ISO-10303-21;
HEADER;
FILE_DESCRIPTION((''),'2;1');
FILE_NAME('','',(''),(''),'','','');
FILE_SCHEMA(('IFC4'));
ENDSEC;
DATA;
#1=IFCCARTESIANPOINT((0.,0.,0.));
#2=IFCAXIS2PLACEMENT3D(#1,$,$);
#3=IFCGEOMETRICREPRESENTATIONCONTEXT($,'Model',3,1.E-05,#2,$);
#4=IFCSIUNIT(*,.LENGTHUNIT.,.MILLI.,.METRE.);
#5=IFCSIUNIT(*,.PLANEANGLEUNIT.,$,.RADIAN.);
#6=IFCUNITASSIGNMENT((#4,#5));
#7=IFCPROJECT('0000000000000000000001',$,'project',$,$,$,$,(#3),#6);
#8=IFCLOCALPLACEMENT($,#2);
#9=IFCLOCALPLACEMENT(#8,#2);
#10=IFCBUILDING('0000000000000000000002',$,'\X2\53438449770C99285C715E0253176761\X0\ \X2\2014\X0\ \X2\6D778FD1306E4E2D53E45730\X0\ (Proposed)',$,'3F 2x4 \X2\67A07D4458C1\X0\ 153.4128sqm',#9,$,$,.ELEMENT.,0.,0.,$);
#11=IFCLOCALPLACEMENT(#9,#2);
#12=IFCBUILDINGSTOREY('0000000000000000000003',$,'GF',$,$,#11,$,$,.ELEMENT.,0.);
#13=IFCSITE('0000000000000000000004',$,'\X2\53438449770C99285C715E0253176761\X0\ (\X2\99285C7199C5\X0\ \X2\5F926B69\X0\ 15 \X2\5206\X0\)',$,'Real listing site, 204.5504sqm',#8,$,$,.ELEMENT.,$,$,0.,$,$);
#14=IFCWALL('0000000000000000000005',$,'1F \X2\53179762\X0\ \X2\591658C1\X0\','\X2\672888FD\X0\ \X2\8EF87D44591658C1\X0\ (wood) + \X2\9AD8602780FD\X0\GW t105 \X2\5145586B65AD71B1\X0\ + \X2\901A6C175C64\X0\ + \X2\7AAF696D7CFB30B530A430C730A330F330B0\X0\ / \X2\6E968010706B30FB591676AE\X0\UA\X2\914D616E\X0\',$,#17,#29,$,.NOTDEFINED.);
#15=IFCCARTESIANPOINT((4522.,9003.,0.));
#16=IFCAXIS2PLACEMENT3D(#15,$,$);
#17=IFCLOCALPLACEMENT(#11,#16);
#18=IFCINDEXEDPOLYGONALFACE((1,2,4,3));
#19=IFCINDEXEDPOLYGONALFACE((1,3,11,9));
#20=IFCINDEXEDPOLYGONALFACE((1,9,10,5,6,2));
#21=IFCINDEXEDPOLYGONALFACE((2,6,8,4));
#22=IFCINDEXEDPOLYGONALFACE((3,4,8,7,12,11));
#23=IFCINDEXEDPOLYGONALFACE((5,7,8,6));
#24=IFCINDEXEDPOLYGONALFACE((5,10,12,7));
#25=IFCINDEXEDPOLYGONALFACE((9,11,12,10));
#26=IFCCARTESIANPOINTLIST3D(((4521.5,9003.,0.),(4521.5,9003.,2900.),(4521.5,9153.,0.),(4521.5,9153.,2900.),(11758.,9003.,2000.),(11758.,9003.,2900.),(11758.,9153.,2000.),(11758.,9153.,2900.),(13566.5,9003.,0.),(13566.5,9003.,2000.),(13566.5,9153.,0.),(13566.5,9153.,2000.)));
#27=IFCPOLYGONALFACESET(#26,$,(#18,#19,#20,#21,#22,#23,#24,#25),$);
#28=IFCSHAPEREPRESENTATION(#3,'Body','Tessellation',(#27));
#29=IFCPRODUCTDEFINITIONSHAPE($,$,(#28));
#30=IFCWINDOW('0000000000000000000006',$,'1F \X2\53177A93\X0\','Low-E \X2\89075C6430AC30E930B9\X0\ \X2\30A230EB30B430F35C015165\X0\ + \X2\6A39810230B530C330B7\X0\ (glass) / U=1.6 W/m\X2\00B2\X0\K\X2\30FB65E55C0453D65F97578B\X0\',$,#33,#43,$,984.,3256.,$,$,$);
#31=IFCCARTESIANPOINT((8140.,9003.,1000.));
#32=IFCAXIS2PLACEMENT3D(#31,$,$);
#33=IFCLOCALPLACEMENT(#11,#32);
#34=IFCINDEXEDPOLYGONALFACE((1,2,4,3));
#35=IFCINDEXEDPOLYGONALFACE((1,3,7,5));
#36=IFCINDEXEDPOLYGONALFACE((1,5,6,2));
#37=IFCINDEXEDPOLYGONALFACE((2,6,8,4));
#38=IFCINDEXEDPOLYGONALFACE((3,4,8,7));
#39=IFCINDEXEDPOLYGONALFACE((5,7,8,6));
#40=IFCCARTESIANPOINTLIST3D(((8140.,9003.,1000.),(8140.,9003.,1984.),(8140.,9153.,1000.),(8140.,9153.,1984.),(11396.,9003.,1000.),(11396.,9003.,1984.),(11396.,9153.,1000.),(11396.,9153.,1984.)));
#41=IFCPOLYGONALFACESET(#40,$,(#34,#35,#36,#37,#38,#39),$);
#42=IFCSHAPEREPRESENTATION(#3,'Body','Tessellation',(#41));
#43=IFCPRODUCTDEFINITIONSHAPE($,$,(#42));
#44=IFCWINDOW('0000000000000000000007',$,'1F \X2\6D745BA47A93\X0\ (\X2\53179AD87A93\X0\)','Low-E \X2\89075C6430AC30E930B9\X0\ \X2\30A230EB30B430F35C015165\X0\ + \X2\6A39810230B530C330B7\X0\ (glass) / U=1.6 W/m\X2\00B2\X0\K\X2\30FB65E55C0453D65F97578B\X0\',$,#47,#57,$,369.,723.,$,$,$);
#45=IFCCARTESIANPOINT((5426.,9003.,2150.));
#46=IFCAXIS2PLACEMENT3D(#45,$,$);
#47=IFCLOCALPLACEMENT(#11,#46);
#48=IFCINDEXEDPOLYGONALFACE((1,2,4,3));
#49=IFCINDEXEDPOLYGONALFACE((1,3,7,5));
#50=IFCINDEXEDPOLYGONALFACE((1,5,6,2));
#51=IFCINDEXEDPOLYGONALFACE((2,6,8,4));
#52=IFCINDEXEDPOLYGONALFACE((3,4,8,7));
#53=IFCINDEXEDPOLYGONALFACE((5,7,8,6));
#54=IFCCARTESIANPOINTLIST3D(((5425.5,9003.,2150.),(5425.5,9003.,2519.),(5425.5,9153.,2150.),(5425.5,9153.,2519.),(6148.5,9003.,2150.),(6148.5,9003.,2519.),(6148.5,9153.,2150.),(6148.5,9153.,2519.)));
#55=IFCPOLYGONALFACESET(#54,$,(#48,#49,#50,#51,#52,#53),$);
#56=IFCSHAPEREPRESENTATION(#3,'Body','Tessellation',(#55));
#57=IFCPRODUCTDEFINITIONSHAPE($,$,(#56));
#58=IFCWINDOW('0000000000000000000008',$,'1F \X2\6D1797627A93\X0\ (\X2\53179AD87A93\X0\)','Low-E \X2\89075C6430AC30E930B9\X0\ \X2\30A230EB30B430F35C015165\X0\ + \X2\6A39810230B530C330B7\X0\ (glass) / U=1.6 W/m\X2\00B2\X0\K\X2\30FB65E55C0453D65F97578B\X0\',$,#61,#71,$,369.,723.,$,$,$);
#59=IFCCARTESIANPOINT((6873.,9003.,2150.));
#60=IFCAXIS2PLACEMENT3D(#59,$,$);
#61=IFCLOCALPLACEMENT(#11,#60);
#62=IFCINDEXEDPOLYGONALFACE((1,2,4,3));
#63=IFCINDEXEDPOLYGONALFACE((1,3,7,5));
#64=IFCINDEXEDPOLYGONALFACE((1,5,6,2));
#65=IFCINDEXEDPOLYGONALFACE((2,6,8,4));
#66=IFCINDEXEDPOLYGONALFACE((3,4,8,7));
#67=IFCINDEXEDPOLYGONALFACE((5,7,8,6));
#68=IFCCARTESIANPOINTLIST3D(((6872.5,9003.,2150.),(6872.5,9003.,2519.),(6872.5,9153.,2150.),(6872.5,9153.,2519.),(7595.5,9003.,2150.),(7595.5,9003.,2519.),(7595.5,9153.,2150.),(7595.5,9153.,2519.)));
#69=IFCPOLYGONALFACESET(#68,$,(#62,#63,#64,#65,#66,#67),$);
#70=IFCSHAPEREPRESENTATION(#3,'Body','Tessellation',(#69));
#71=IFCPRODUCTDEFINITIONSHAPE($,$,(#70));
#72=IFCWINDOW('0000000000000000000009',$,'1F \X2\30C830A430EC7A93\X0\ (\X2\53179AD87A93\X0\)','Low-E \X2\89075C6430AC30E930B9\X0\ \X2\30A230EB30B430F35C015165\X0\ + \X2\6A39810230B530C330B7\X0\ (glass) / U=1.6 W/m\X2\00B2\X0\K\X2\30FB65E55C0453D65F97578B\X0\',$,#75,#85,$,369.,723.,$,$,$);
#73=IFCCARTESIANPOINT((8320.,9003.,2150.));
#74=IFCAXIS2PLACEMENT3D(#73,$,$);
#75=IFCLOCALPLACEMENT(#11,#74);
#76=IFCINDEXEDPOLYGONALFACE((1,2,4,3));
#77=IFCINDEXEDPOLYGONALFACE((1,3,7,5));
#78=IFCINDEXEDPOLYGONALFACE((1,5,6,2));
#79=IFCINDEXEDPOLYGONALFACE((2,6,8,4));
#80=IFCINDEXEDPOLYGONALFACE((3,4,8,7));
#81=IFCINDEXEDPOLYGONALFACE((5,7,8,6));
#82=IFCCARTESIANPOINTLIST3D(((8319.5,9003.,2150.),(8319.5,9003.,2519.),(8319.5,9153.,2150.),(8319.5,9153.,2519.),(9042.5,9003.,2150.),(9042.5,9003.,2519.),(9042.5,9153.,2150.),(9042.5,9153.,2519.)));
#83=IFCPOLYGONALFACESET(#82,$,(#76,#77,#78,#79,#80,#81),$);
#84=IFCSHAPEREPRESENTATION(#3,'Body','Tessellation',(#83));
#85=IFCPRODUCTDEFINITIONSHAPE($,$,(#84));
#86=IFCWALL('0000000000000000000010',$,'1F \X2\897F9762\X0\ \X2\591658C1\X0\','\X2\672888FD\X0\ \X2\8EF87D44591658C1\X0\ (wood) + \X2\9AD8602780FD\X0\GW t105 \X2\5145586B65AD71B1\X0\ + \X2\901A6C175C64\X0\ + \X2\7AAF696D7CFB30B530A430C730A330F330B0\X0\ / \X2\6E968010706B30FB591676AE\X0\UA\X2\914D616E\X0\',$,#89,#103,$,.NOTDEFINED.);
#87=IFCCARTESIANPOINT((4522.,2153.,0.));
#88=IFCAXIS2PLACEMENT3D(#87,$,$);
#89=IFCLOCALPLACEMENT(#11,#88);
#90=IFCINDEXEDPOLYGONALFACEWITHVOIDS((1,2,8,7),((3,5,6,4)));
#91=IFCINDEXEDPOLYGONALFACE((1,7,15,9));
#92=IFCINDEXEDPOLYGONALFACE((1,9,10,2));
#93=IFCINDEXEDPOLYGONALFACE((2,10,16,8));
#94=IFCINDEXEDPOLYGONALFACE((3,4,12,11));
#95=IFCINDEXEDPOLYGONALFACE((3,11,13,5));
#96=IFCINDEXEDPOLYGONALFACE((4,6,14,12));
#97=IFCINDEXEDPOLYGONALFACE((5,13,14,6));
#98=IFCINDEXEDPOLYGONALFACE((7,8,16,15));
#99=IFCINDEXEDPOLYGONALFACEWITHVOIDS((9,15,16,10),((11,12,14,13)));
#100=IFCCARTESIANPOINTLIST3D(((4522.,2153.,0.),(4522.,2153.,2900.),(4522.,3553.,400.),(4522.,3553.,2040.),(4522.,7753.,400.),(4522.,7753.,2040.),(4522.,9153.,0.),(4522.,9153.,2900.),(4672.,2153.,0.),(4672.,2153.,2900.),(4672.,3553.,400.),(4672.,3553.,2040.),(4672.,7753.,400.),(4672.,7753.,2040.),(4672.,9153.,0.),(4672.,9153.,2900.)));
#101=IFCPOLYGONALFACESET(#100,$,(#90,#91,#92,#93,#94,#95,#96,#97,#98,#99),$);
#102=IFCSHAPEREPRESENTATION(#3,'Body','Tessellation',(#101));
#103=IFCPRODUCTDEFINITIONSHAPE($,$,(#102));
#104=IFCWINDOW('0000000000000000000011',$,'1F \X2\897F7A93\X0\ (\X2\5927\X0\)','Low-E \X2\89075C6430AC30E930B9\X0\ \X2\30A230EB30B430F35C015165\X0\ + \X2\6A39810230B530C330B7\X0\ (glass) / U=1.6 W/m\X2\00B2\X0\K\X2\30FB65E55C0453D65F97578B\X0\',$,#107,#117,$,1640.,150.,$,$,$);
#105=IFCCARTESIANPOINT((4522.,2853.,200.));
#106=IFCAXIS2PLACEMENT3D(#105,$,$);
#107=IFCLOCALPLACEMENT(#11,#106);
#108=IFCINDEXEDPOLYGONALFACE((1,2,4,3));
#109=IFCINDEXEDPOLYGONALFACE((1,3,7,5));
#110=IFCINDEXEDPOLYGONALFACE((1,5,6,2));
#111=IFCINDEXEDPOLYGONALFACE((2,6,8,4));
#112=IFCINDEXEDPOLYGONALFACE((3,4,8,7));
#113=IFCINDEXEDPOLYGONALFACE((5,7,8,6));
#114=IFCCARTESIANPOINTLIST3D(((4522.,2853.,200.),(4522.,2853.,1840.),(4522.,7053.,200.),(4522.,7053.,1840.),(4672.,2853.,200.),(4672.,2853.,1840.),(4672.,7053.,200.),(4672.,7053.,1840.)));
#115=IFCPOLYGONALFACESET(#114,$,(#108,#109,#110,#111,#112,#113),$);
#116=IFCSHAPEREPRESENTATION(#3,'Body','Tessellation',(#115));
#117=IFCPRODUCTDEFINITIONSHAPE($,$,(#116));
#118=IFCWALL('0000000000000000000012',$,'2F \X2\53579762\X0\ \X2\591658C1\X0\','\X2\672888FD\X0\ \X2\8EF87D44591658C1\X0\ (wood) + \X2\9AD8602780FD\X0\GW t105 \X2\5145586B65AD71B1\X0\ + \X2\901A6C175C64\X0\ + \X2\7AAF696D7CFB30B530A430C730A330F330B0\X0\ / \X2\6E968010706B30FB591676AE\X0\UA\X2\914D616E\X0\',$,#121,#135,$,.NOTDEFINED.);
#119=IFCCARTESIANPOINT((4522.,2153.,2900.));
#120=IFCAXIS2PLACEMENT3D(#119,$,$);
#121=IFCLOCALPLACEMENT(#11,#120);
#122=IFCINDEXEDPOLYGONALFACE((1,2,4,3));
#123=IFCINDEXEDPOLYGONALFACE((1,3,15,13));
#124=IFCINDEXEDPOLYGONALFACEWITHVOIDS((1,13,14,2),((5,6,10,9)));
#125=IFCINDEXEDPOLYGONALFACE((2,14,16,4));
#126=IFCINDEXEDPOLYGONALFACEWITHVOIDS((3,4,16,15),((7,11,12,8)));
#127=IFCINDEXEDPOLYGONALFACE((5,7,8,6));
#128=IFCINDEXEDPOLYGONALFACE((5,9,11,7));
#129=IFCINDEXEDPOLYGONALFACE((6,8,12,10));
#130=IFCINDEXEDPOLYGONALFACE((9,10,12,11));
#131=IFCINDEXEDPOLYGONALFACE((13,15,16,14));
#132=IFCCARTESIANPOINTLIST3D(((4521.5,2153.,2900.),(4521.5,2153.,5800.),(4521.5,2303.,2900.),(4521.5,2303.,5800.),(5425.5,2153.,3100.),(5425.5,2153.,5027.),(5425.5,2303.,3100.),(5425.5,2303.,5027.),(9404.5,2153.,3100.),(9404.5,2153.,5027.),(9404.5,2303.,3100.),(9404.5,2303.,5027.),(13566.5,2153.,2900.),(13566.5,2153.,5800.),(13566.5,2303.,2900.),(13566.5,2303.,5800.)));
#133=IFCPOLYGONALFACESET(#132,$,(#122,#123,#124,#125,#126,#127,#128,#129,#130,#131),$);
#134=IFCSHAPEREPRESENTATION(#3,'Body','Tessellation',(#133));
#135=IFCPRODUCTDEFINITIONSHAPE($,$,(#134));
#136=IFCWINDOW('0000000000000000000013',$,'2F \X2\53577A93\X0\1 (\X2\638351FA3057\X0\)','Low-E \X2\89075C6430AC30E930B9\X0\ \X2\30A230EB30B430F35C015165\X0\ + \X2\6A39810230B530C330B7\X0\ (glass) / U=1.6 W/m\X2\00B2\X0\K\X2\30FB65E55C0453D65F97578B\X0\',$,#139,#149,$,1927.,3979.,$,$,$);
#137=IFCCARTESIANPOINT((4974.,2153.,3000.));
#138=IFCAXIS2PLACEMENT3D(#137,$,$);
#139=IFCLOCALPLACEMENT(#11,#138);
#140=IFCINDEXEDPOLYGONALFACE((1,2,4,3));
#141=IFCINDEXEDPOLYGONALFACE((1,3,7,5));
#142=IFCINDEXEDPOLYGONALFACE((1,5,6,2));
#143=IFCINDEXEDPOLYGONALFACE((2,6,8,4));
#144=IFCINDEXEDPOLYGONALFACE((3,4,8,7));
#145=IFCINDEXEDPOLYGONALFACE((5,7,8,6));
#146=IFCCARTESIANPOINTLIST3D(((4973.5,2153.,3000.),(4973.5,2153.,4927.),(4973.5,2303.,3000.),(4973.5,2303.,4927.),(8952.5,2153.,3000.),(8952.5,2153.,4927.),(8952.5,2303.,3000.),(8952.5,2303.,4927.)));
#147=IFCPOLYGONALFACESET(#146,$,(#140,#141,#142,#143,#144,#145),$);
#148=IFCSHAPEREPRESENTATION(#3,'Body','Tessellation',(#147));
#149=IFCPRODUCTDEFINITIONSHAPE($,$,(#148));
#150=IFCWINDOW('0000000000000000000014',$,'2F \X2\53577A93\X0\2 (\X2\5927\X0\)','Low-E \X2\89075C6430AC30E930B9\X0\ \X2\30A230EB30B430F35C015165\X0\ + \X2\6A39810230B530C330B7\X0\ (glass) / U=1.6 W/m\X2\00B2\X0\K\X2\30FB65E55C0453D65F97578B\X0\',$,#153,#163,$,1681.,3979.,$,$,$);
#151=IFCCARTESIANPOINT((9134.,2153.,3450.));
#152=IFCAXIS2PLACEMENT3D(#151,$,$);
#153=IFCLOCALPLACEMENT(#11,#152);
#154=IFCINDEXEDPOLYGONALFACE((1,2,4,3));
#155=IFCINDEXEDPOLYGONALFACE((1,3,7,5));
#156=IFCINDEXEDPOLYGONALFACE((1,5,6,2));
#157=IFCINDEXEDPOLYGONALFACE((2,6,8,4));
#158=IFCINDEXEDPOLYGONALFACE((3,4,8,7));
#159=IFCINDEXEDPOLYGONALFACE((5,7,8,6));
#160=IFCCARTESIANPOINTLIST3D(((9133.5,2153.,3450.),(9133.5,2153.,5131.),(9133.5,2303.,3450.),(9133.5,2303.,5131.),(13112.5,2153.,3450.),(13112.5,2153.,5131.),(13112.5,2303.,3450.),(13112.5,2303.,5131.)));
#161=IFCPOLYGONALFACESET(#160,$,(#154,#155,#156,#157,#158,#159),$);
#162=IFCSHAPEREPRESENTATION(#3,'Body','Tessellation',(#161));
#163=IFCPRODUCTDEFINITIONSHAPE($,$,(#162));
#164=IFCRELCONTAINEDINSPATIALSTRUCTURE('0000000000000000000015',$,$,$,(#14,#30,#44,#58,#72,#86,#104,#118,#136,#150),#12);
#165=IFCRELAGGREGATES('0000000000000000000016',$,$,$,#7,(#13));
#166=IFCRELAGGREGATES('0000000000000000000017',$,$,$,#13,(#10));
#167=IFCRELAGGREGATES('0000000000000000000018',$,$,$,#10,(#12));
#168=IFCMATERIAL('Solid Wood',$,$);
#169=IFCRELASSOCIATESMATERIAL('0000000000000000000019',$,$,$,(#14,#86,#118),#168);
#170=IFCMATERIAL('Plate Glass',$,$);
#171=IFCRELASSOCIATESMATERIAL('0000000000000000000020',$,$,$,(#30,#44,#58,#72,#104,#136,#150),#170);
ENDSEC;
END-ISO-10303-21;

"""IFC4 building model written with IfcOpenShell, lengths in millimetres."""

from ifc_helpers import new_model, si_unit, frame, frame_2d, origin, place, context, project, spatial, rectangle, extrude, material, element, fill, save


model = new_model("IFC4")

# Units and contexts
model_context = context("Model", 3, precision=1e-05, world=origin())
ifc_project = project(units=[si_unit("LENGTHUNIT", "METRE", prefix="MILLI"), si_unit("PLANEANGLEUNIT", "RADIAN")], contexts=[model_context])

# Site, building, storey
site_placement = place(None, origin())
site = spatial("IfcSite", under=ifc_project, at=site_placement, Name="千葉県館山市北条 (館山駅 徒歩 15 分)", ObjectType="Real listing site, 204.5504sqm", CompositionType="ELEMENT", RefElevation=0.0)
building_placement = place(site_placement, origin())
building = spatial("IfcBuilding", under=site, at=building_placement, Name="千葉県館山市北条 — 海近の中古地 (Proposed)", ObjectType="3F 2x4 枠組壁 153.4128sqm", CompositionType="ELEMENT", ElevationOfRefHeight=0.0, ElevationOfTerrain=0.0)
storey_placement = place(building_placement, origin())
storey = spatial("IfcBuildingStorey", under=building, at=storey_placement, Name="GF", CompositionType="ELEMENT", Elevation=0.0)

# Shared definitions
ifc_material_1 = material(Name="Solid Wood")

# Shared definitions
ifc_material_2 = material(Name="Plate Glass")

# Wall, openings, windows
wall_1_placement = place(storey_placement, frame((4522.0, 9003.0, 0.0)))
wall_1 = element("IfcWall", 1, at=wall_1_placement, inside=storey, material=ifc_material_1, Name="1F 北面 外壁", Description="木製 軸組外壁 (wood) + 高性能GW t105 充填断熱 + 通気層 + 窯業系サイディング / 準耐火・外皮UA配慮", PredefinedType="NOTDEFINED", context=model_context, shape_type="SweptSolid", body=[
    extrude(rectangle(XDim=9045.0, YDim=150.0, at=frame_2d((4522.0, 75.0))), frame((4522.0, 9003.0, 0.0)), (0.0, 0.0, 1.0), 2900.0),
])
opening_1_placement = place(storey_placement, frame((8140.0, 9003.0, 1000.0)))
opening_1 = element("IfcOpeningElement", 2, at=opening_1_placement, cuts=wall_1, PredefinedType="NOTDEFINED", context=model_context, shape_type="SweptSolid", body=[
    extrude(rectangle(XDim=3256.0, YDim=150.0, at=frame_2d((1628.0, 75.0))), frame((8140.0, 9003.0, 1000.0)), (0.0, 0.0, 1.0), 984.0),
])
opening_2_placement = place(storey_placement, frame((5426.0, 9003.0, 2150.0)))
opening_2 = element("IfcOpeningElement", 3, at=opening_2_placement, cuts=wall_1, PredefinedType="NOTDEFINED", context=model_context, shape_type="SweptSolid", body=[
    extrude(rectangle(XDim=723.0, YDim=150.0, at=frame_2d((361.0, 75.0))), frame((5426.0, 9003.0, 2150.0)), (0.0, 0.0, 1.0), 369.0),
])
opening_3_placement = place(storey_placement, frame((6873.0, 9003.0, 2150.0)))
opening_3 = element("IfcOpeningElement", 4, at=opening_3_placement, cuts=wall_1, PredefinedType="NOTDEFINED", context=model_context, shape_type="SweptSolid", body=[
    extrude(rectangle(XDim=723.0, YDim=150.0, at=frame_2d((361.0, 75.0))), frame((6873.0, 9003.0, 2150.0)), (0.0, 0.0, 1.0), 369.0),
])
opening_4_placement = place(storey_placement, frame((8320.0, 9003.0, 2150.0)))
opening_4 = element("IfcOpeningElement", 5, at=opening_4_placement, cuts=wall_1, PredefinedType="NOTDEFINED", context=model_context, shape_type="SweptSolid", body=[
    extrude(rectangle(XDim=723.0, YDim=150.0, at=frame_2d((361.0, 75.0))), frame((8320.0, 9003.0, 2150.0)), (0.0, 0.0, 1.0), 369.0),
])
window_1_placement = place(storey_placement, frame((8140.0, 9003.0, 1000.0)))
window_1 = element("IfcWindow", 6, at=window_1_placement, inside=storey, material=ifc_material_2, Name="1F 北窓", Description="Low-E 複層ガラス アルゴン封入 + 樹脂サッシ (glass) / U=1.6 W/m²K・日射取得型", OverallHeight=984.0, OverallWidth=3256.0, context=model_context, shape_type="SweptSolid", body=[
    extrude(rectangle(XDim=3256.0, YDim=150.0, at=frame_2d((1628.0, 75.0))), frame((8140.0, 9003.0, 1000.0)), (0.0, 0.0, 1.0), 984.0),
])
fill(opening_1, window_1)
window_2_placement = place(storey_placement, frame((5426.0, 9003.0, 2150.0)))
window_2 = element("IfcWindow", 7, at=window_2_placement, inside=storey, material=ifc_material_2, Name="1F 浴室窓 (北高窓)", Description="Low-E 複層ガラス アルゴン封入 + 樹脂サッシ (glass) / U=1.6 W/m²K・日射取得型", OverallHeight=369.0, OverallWidth=723.0, context=model_context, shape_type="SweptSolid", body=[
    extrude(rectangle(XDim=723.0, YDim=150.0, at=frame_2d((361.0, 75.0))), frame((5426.0, 9003.0, 2150.0)), (0.0, 0.0, 1.0), 369.0),
])
fill(opening_2, window_2)
window_3_placement = place(storey_placement, frame((6873.0, 9003.0, 2150.0)))
window_3 = element("IfcWindow", 8, at=window_3_placement, inside=storey, material=ifc_material_2, Name="1F 洗面窓 (北高窓)", Description="Low-E 複層ガラス アルゴン封入 + 樹脂サッシ (glass) / U=1.6 W/m²K・日射取得型", OverallHeight=369.0, OverallWidth=723.0, context=model_context, shape_type="SweptSolid", body=[
    extrude(rectangle(XDim=723.0, YDim=150.0, at=frame_2d((361.0, 75.0))), frame((6873.0, 9003.0, 2150.0)), (0.0, 0.0, 1.0), 369.0),
])
fill(opening_3, window_3)
window_4_placement = place(storey_placement, frame((8320.0, 9003.0, 2150.0)))
window_4 = element("IfcWindow", 9, at=window_4_placement, inside=storey, material=ifc_material_2, Name="1F トイレ窓 (北高窓)", Description="Low-E 複層ガラス アルゴン封入 + 樹脂サッシ (glass) / U=1.6 W/m²K・日射取得型", OverallHeight=369.0, OverallWidth=723.0, context=model_context, shape_type="SweptSolid", body=[
    extrude(rectangle(XDim=723.0, YDim=150.0, at=frame_2d((361.0, 75.0))), frame((8320.0, 9003.0, 2150.0)), (0.0, 0.0, 1.0), 369.0),
])
fill(opening_4, window_4)

# Wall, opening, window
wall_2_placement = place(storey_placement, frame((4522.0, 2153.0, 0.0)))
wall_2 = element("IfcWall", 10, at=wall_2_placement, inside=storey, material=ifc_material_1, Name="1F 西面 外壁", Description="木製 軸組外壁 (wood) + 高性能GW t105 充填断熱 + 通気層 + 窯業系サイディング / 準耐火・外皮UA配慮", PredefinedType="NOTDEFINED", context=model_context, shape_type="SweptSolid", body=[
    extrude(rectangle(XDim=150.0, YDim=7000.0, at=frame_2d((75.0, 3500.0))), frame((4522.0, 2153.0, 0.0)), (0.0, 0.0, 1.0), 2900.0),
])
opening_5_placement = place(storey_placement, frame((4522.0, 2853.0, 200.0)))
opening_5 = element("IfcOpeningElement", 11, at=opening_5_placement, cuts=wall_2, PredefinedType="NOTDEFINED", context=model_context, shape_type="SweptSolid", body=[
    extrude(rectangle(XDim=150.0, YDim=4200.0, at=frame_2d((75.0, 2100.0))), frame((4522.0, 2853.0, 200.0)), (0.0, 0.0, 1.0), 1640.0),
])
window_5_placement = place(storey_placement, frame((4522.0, 2853.0, 200.0)))
window_5 = element("IfcWindow", 12, at=window_5_placement, inside=storey, material=ifc_material_2, Name="1F 西窓 (大)", Description="Low-E 複層ガラス アルゴン封入 + 樹脂サッシ (glass) / U=1.6 W/m²K・日射取得型", OverallHeight=1640.0, OverallWidth=150.0, context=model_context, shape_type="SweptSolid", body=[
    extrude(rectangle(XDim=150.0, YDim=4200.0, at=frame_2d((75.0, 2100.0))), frame((4522.0, 2853.0, 200.0)), (0.0, 0.0, 1.0), 1640.0),
])
fill(opening_5, window_5)

# Wall, openings, windows
wall_3_placement = place(storey_placement, frame((4522.0, 2153.0, 2900.0)))
wall_3 = element("IfcWall", 13, at=wall_3_placement, inside=storey, material=ifc_material_1, Name="2F 南面 外壁", Description="木製 軸組外壁 (wood) + 高性能GW t105 充填断熱 + 通気層 + 窯業系サイディング / 準耐火・外皮UA配慮", PredefinedType="NOTDEFINED", context=model_context, shape_type="SweptSolid", body=[
    extrude(rectangle(XDim=9045.0, YDim=150.0, at=frame_2d((4522.0, 75.0))), frame((4522.0, 2153.0, 2900.0)), (0.0, 0.0, 1.0), 2900.0),
])
opening_6_placement = place(storey_placement, frame((4974.0, 2153.0, 3000.0)))
opening_6 = element("IfcOpeningElement", 14, at=opening_6_placement, cuts=wall_3, PredefinedType="NOTDEFINED", context=model_context, shape_type="SweptSolid", body=[
    extrude(rectangle(XDim=3979.0, YDim=150.0, at=frame_2d((1989.0, 75.0))), frame((4974.0, 2153.0, 3000.0)), (0.0, 0.0, 1.0), 1927.0),
])
opening_7_placement = place(storey_placement, frame((9134.0, 2153.0, 3450.0)))
opening_7 = element("IfcOpeningElement", 15, at=opening_7_placement, cuts=wall_3, PredefinedType="NOTDEFINED", context=model_context, shape_type="SweptSolid", body=[
    extrude(rectangle(XDim=3979.0, YDim=150.0, at=frame_2d((1989.0, 75.0))), frame((9134.0, 2153.0, 3450.0)), (0.0, 0.0, 1.0), 1681.0),
])
window_6_placement = place(storey_placement, frame((4974.0, 2153.0, 3000.0)))
window_6 = element("IfcWindow", 16, at=window_6_placement, inside=storey, material=ifc_material_2, Name="2F 南窓1 (掃出し)", Description="Low-E 複層ガラス アルゴン封入 + 樹脂サッシ (glass) / U=1.6 W/m²K・日射取得型", OverallHeight=1927.0, OverallWidth=3979.0, context=model_context, shape_type="SweptSolid", body=[
    extrude(rectangle(XDim=3979.0, YDim=150.0, at=frame_2d((1989.0, 75.0))), frame((4974.0, 2153.0, 3000.0)), (0.0, 0.0, 1.0), 1927.0),
])
fill(opening_6, window_6)
window_7_placement = place(storey_placement, frame((9134.0, 2153.0, 3450.0)))
window_7 = element("IfcWindow", 17, at=window_7_placement, inside=storey, material=ifc_material_2, Name="2F 南窓2 (大)", Description="Low-E 複層ガラス アルゴン封入 + 樹脂サッシ (glass) / U=1.6 W/m²K・日射取得型", OverallHeight=1681.0, OverallWidth=3979.0, context=model_context, shape_type="SweptSolid", body=[
    extrude(rectangle(XDim=3979.0, YDim=150.0, at=frame_2d((1989.0, 75.0))), frame((9134.0, 2153.0, 3450.0)), (0.0, 0.0, 1.0), 1681.0),
])
fill(opening_7, window_7)

save(model, "model.ifc")
